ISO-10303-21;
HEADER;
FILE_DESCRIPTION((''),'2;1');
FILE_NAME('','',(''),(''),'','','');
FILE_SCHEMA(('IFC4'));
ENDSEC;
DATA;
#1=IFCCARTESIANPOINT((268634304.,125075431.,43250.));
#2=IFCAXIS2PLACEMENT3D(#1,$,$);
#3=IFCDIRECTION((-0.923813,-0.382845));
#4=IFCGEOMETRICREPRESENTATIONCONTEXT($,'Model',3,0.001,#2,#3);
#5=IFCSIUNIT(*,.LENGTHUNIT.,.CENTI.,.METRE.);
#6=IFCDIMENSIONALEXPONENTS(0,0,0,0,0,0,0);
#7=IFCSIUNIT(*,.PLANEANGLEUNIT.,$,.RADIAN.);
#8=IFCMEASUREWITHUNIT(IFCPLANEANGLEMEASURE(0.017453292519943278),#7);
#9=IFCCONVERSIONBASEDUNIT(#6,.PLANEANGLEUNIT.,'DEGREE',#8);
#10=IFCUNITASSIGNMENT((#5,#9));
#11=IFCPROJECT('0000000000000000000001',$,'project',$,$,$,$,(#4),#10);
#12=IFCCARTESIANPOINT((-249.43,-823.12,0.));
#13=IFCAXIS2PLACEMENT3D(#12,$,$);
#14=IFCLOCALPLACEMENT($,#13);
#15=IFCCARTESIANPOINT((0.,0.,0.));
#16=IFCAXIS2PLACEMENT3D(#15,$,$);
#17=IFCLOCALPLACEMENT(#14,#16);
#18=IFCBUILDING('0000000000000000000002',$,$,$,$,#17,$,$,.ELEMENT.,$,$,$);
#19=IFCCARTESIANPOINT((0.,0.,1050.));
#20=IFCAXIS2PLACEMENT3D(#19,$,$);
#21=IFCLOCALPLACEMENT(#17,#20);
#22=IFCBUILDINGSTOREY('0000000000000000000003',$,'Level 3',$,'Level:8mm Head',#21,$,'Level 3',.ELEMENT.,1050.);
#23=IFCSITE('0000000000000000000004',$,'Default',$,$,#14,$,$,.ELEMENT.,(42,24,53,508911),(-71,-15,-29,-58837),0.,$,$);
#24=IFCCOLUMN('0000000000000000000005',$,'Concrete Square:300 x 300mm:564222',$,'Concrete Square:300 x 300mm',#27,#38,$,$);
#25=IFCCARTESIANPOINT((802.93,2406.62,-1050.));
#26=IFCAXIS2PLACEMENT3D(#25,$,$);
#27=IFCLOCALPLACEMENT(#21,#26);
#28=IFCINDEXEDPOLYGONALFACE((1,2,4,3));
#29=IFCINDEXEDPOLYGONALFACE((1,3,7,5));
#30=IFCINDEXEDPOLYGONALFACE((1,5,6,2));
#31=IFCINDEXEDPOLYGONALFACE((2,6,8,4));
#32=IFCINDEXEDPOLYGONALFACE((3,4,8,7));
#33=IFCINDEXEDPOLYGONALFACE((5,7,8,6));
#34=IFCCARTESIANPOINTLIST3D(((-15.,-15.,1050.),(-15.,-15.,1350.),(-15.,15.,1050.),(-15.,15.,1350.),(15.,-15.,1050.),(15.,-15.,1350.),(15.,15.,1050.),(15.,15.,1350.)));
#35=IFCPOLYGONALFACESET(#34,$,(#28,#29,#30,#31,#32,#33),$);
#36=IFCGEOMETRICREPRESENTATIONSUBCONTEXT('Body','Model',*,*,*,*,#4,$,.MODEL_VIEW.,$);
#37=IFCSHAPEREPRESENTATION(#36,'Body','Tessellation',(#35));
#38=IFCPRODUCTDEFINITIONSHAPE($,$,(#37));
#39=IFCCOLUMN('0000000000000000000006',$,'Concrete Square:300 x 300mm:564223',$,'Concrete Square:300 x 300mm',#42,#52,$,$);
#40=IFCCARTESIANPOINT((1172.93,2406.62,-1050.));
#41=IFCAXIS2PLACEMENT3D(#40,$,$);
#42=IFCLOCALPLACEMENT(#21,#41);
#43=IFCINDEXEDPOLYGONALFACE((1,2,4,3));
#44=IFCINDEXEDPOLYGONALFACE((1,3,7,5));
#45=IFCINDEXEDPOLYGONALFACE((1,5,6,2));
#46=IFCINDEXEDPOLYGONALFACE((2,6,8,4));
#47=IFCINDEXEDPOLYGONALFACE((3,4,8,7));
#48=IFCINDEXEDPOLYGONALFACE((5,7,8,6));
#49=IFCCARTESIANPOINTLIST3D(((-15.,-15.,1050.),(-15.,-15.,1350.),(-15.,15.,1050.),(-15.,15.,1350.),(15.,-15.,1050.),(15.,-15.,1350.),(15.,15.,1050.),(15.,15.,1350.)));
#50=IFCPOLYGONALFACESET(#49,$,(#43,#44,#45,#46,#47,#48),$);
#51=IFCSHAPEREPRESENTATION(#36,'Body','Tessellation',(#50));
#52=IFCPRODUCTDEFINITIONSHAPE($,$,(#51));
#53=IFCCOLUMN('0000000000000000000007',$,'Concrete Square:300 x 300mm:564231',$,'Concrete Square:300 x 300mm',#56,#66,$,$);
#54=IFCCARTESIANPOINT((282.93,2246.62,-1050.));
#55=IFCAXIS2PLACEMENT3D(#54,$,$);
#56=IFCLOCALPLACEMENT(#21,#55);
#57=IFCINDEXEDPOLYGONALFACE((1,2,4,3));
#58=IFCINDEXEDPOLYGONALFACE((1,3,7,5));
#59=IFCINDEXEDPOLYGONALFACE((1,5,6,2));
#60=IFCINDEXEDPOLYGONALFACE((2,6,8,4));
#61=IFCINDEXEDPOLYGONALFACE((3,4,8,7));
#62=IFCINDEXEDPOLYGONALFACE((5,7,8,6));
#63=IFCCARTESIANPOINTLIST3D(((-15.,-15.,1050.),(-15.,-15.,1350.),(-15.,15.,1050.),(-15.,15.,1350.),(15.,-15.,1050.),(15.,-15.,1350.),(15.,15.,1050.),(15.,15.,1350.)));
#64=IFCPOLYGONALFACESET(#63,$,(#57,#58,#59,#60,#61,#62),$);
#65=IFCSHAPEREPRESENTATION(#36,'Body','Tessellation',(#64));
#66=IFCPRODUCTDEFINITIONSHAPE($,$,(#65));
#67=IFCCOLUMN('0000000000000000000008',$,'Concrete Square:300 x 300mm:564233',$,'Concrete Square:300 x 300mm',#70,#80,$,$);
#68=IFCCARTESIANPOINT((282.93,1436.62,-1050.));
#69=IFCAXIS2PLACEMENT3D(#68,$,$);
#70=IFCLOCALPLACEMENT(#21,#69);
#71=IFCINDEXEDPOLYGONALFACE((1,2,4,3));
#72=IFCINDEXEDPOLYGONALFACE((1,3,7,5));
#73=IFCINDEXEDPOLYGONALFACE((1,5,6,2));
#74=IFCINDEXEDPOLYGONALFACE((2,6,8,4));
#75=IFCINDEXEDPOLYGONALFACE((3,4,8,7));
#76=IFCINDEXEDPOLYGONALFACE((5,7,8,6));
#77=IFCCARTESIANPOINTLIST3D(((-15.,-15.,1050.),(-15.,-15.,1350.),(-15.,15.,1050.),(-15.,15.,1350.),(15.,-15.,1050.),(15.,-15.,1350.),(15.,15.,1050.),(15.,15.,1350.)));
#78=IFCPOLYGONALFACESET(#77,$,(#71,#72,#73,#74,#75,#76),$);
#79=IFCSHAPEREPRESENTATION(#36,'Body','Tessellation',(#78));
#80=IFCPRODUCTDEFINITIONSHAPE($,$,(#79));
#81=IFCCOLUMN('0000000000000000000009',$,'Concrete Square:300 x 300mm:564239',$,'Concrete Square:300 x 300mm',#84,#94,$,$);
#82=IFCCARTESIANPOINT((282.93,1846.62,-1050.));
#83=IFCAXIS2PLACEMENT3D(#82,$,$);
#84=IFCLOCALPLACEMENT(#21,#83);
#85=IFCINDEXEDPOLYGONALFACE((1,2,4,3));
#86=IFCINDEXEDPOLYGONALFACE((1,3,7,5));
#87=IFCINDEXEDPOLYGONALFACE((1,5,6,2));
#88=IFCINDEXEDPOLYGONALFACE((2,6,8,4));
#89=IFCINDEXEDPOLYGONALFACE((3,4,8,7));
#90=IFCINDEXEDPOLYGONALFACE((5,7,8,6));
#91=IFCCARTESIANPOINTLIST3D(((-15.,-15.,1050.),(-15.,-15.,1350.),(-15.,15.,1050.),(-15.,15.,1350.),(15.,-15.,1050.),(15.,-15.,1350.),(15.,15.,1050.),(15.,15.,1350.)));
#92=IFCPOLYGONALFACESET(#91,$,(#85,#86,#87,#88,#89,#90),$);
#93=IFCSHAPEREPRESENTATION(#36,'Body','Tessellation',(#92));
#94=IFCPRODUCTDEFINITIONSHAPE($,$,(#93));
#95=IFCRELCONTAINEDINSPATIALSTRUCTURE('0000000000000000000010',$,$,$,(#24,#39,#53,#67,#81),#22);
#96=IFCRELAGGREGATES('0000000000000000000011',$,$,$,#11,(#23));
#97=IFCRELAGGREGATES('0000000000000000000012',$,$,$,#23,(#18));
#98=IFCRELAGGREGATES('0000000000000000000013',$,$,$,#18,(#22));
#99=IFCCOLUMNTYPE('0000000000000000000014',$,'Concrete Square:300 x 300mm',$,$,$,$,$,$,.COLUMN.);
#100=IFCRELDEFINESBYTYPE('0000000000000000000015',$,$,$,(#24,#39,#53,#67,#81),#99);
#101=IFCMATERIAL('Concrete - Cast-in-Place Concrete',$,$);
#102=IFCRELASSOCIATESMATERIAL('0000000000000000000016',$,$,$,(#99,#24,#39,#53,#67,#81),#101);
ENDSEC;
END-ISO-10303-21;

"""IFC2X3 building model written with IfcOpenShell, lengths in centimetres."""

from ifc_helpers import new_model, entity, si_unit, converted_unit, direction, frame, origin, origin_2d_with_axis, place, context, subcontext, project, spatial, rectangle, extrude, source, transform, mapped, material, type_object, type_shapes, element, save


model = new_model("IFC2X3")

# Units and contexts
model_context = context("Model", 3, precision=0.001, world=frame((268634304.0, 125075431.0, 43250.0)), true_north=direction((-0.923813, -0.382845)))
body_context = subcontext(model_context, "Body", "Model", "MODEL_VIEW")
ifc_project = project(units=[si_unit("LENGTHUNIT", "METRE", prefix="CENTI"), converted_unit("PLANEANGLEUNIT", "DEGREE", entity("IfcPlaneAngleMeasure", 0.017453292519943278), si_unit("PLANEANGLEUNIT", "RADIAN"), dimensions=[0, 0, 0, 0, 0, 0, 0])], contexts=[model_context])

# Site, building, storey
site_placement = place(None, frame((-249.43, -823.12, 0.0)))
site = spatial("IfcSite", under=ifc_project, at=site_placement, Name="Default", CompositionType="ELEMENT", RefLatitude=(42, 24, 53, 508911), RefLongitude=(-71, -15, -29, -58837), RefElevation=0.0)
building_placement = place(site_placement, origin())
building = spatial("IfcBuilding", under=site, at=building_placement, CompositionType="ELEMENT")
storey_placement = place(building_placement, frame((0.0, 0.0, 1050.0)))
storey = spatial("IfcBuildingStorey", under=building, at=storey_placement, Name="Level 3", ObjectType="Level:8mm Head", LongName="Level 3", CompositionType="ELEMENT", Elevation=1050.0)

# Columns
ifc_material_1 = material(Name="Concrete - Cast-in-Place Concrete")
column_type = type_object("IfcColumnType", Name="Concrete Square:300 x 300mm", PredefinedType="COLUMN", material=ifc_material_1)
shared_shape_1 = source(origin(), body_context, "Body", "SweptSolid", [
    extrude(rectangle(XDim=30.0, YDim=30.0, at=origin_2d_with_axis()), frame((0.0, 0.0, 1050.0), z_axis=(0.0, 0.0, 1.0), x_axis=(-1.0, 0.0, 0.0)), (0.0, 0.0, 1.0), 300.0),
])
type_shapes(column_type, [shared_shape_1])
for number, where, name in (
    (1, (802.93, 2406.62, -1050.0), "Concrete Square:300 x 300mm:564222"),
    (2, (1172.93, 2406.62, -1050.0), "Concrete Square:300 x 300mm:564223"),
    (3, (282.93, 2246.62, -1050.0), "Concrete Square:300 x 300mm:564231"),
    (4, (282.93, 1436.62, -1050.0), "Concrete Square:300 x 300mm:564233"),
    (5, (282.93, 1846.62, -1050.0), "Concrete Square:300 x 300mm:564239"),
):
    element("IfcColumn", number, at=place(storey_placement, frame(where)), inside=storey, type_object=column_type, material=ifc_material_1, Name=name, ObjectType="Concrete Square:300 x 300mm", context=body_context, shape_type="MappedRepresentation", body=[
        mapped(shared_shape_1, transform((0.0, 0.0, 0.0), scale=1.0)),
    ])

save(model, "model.ifc")
